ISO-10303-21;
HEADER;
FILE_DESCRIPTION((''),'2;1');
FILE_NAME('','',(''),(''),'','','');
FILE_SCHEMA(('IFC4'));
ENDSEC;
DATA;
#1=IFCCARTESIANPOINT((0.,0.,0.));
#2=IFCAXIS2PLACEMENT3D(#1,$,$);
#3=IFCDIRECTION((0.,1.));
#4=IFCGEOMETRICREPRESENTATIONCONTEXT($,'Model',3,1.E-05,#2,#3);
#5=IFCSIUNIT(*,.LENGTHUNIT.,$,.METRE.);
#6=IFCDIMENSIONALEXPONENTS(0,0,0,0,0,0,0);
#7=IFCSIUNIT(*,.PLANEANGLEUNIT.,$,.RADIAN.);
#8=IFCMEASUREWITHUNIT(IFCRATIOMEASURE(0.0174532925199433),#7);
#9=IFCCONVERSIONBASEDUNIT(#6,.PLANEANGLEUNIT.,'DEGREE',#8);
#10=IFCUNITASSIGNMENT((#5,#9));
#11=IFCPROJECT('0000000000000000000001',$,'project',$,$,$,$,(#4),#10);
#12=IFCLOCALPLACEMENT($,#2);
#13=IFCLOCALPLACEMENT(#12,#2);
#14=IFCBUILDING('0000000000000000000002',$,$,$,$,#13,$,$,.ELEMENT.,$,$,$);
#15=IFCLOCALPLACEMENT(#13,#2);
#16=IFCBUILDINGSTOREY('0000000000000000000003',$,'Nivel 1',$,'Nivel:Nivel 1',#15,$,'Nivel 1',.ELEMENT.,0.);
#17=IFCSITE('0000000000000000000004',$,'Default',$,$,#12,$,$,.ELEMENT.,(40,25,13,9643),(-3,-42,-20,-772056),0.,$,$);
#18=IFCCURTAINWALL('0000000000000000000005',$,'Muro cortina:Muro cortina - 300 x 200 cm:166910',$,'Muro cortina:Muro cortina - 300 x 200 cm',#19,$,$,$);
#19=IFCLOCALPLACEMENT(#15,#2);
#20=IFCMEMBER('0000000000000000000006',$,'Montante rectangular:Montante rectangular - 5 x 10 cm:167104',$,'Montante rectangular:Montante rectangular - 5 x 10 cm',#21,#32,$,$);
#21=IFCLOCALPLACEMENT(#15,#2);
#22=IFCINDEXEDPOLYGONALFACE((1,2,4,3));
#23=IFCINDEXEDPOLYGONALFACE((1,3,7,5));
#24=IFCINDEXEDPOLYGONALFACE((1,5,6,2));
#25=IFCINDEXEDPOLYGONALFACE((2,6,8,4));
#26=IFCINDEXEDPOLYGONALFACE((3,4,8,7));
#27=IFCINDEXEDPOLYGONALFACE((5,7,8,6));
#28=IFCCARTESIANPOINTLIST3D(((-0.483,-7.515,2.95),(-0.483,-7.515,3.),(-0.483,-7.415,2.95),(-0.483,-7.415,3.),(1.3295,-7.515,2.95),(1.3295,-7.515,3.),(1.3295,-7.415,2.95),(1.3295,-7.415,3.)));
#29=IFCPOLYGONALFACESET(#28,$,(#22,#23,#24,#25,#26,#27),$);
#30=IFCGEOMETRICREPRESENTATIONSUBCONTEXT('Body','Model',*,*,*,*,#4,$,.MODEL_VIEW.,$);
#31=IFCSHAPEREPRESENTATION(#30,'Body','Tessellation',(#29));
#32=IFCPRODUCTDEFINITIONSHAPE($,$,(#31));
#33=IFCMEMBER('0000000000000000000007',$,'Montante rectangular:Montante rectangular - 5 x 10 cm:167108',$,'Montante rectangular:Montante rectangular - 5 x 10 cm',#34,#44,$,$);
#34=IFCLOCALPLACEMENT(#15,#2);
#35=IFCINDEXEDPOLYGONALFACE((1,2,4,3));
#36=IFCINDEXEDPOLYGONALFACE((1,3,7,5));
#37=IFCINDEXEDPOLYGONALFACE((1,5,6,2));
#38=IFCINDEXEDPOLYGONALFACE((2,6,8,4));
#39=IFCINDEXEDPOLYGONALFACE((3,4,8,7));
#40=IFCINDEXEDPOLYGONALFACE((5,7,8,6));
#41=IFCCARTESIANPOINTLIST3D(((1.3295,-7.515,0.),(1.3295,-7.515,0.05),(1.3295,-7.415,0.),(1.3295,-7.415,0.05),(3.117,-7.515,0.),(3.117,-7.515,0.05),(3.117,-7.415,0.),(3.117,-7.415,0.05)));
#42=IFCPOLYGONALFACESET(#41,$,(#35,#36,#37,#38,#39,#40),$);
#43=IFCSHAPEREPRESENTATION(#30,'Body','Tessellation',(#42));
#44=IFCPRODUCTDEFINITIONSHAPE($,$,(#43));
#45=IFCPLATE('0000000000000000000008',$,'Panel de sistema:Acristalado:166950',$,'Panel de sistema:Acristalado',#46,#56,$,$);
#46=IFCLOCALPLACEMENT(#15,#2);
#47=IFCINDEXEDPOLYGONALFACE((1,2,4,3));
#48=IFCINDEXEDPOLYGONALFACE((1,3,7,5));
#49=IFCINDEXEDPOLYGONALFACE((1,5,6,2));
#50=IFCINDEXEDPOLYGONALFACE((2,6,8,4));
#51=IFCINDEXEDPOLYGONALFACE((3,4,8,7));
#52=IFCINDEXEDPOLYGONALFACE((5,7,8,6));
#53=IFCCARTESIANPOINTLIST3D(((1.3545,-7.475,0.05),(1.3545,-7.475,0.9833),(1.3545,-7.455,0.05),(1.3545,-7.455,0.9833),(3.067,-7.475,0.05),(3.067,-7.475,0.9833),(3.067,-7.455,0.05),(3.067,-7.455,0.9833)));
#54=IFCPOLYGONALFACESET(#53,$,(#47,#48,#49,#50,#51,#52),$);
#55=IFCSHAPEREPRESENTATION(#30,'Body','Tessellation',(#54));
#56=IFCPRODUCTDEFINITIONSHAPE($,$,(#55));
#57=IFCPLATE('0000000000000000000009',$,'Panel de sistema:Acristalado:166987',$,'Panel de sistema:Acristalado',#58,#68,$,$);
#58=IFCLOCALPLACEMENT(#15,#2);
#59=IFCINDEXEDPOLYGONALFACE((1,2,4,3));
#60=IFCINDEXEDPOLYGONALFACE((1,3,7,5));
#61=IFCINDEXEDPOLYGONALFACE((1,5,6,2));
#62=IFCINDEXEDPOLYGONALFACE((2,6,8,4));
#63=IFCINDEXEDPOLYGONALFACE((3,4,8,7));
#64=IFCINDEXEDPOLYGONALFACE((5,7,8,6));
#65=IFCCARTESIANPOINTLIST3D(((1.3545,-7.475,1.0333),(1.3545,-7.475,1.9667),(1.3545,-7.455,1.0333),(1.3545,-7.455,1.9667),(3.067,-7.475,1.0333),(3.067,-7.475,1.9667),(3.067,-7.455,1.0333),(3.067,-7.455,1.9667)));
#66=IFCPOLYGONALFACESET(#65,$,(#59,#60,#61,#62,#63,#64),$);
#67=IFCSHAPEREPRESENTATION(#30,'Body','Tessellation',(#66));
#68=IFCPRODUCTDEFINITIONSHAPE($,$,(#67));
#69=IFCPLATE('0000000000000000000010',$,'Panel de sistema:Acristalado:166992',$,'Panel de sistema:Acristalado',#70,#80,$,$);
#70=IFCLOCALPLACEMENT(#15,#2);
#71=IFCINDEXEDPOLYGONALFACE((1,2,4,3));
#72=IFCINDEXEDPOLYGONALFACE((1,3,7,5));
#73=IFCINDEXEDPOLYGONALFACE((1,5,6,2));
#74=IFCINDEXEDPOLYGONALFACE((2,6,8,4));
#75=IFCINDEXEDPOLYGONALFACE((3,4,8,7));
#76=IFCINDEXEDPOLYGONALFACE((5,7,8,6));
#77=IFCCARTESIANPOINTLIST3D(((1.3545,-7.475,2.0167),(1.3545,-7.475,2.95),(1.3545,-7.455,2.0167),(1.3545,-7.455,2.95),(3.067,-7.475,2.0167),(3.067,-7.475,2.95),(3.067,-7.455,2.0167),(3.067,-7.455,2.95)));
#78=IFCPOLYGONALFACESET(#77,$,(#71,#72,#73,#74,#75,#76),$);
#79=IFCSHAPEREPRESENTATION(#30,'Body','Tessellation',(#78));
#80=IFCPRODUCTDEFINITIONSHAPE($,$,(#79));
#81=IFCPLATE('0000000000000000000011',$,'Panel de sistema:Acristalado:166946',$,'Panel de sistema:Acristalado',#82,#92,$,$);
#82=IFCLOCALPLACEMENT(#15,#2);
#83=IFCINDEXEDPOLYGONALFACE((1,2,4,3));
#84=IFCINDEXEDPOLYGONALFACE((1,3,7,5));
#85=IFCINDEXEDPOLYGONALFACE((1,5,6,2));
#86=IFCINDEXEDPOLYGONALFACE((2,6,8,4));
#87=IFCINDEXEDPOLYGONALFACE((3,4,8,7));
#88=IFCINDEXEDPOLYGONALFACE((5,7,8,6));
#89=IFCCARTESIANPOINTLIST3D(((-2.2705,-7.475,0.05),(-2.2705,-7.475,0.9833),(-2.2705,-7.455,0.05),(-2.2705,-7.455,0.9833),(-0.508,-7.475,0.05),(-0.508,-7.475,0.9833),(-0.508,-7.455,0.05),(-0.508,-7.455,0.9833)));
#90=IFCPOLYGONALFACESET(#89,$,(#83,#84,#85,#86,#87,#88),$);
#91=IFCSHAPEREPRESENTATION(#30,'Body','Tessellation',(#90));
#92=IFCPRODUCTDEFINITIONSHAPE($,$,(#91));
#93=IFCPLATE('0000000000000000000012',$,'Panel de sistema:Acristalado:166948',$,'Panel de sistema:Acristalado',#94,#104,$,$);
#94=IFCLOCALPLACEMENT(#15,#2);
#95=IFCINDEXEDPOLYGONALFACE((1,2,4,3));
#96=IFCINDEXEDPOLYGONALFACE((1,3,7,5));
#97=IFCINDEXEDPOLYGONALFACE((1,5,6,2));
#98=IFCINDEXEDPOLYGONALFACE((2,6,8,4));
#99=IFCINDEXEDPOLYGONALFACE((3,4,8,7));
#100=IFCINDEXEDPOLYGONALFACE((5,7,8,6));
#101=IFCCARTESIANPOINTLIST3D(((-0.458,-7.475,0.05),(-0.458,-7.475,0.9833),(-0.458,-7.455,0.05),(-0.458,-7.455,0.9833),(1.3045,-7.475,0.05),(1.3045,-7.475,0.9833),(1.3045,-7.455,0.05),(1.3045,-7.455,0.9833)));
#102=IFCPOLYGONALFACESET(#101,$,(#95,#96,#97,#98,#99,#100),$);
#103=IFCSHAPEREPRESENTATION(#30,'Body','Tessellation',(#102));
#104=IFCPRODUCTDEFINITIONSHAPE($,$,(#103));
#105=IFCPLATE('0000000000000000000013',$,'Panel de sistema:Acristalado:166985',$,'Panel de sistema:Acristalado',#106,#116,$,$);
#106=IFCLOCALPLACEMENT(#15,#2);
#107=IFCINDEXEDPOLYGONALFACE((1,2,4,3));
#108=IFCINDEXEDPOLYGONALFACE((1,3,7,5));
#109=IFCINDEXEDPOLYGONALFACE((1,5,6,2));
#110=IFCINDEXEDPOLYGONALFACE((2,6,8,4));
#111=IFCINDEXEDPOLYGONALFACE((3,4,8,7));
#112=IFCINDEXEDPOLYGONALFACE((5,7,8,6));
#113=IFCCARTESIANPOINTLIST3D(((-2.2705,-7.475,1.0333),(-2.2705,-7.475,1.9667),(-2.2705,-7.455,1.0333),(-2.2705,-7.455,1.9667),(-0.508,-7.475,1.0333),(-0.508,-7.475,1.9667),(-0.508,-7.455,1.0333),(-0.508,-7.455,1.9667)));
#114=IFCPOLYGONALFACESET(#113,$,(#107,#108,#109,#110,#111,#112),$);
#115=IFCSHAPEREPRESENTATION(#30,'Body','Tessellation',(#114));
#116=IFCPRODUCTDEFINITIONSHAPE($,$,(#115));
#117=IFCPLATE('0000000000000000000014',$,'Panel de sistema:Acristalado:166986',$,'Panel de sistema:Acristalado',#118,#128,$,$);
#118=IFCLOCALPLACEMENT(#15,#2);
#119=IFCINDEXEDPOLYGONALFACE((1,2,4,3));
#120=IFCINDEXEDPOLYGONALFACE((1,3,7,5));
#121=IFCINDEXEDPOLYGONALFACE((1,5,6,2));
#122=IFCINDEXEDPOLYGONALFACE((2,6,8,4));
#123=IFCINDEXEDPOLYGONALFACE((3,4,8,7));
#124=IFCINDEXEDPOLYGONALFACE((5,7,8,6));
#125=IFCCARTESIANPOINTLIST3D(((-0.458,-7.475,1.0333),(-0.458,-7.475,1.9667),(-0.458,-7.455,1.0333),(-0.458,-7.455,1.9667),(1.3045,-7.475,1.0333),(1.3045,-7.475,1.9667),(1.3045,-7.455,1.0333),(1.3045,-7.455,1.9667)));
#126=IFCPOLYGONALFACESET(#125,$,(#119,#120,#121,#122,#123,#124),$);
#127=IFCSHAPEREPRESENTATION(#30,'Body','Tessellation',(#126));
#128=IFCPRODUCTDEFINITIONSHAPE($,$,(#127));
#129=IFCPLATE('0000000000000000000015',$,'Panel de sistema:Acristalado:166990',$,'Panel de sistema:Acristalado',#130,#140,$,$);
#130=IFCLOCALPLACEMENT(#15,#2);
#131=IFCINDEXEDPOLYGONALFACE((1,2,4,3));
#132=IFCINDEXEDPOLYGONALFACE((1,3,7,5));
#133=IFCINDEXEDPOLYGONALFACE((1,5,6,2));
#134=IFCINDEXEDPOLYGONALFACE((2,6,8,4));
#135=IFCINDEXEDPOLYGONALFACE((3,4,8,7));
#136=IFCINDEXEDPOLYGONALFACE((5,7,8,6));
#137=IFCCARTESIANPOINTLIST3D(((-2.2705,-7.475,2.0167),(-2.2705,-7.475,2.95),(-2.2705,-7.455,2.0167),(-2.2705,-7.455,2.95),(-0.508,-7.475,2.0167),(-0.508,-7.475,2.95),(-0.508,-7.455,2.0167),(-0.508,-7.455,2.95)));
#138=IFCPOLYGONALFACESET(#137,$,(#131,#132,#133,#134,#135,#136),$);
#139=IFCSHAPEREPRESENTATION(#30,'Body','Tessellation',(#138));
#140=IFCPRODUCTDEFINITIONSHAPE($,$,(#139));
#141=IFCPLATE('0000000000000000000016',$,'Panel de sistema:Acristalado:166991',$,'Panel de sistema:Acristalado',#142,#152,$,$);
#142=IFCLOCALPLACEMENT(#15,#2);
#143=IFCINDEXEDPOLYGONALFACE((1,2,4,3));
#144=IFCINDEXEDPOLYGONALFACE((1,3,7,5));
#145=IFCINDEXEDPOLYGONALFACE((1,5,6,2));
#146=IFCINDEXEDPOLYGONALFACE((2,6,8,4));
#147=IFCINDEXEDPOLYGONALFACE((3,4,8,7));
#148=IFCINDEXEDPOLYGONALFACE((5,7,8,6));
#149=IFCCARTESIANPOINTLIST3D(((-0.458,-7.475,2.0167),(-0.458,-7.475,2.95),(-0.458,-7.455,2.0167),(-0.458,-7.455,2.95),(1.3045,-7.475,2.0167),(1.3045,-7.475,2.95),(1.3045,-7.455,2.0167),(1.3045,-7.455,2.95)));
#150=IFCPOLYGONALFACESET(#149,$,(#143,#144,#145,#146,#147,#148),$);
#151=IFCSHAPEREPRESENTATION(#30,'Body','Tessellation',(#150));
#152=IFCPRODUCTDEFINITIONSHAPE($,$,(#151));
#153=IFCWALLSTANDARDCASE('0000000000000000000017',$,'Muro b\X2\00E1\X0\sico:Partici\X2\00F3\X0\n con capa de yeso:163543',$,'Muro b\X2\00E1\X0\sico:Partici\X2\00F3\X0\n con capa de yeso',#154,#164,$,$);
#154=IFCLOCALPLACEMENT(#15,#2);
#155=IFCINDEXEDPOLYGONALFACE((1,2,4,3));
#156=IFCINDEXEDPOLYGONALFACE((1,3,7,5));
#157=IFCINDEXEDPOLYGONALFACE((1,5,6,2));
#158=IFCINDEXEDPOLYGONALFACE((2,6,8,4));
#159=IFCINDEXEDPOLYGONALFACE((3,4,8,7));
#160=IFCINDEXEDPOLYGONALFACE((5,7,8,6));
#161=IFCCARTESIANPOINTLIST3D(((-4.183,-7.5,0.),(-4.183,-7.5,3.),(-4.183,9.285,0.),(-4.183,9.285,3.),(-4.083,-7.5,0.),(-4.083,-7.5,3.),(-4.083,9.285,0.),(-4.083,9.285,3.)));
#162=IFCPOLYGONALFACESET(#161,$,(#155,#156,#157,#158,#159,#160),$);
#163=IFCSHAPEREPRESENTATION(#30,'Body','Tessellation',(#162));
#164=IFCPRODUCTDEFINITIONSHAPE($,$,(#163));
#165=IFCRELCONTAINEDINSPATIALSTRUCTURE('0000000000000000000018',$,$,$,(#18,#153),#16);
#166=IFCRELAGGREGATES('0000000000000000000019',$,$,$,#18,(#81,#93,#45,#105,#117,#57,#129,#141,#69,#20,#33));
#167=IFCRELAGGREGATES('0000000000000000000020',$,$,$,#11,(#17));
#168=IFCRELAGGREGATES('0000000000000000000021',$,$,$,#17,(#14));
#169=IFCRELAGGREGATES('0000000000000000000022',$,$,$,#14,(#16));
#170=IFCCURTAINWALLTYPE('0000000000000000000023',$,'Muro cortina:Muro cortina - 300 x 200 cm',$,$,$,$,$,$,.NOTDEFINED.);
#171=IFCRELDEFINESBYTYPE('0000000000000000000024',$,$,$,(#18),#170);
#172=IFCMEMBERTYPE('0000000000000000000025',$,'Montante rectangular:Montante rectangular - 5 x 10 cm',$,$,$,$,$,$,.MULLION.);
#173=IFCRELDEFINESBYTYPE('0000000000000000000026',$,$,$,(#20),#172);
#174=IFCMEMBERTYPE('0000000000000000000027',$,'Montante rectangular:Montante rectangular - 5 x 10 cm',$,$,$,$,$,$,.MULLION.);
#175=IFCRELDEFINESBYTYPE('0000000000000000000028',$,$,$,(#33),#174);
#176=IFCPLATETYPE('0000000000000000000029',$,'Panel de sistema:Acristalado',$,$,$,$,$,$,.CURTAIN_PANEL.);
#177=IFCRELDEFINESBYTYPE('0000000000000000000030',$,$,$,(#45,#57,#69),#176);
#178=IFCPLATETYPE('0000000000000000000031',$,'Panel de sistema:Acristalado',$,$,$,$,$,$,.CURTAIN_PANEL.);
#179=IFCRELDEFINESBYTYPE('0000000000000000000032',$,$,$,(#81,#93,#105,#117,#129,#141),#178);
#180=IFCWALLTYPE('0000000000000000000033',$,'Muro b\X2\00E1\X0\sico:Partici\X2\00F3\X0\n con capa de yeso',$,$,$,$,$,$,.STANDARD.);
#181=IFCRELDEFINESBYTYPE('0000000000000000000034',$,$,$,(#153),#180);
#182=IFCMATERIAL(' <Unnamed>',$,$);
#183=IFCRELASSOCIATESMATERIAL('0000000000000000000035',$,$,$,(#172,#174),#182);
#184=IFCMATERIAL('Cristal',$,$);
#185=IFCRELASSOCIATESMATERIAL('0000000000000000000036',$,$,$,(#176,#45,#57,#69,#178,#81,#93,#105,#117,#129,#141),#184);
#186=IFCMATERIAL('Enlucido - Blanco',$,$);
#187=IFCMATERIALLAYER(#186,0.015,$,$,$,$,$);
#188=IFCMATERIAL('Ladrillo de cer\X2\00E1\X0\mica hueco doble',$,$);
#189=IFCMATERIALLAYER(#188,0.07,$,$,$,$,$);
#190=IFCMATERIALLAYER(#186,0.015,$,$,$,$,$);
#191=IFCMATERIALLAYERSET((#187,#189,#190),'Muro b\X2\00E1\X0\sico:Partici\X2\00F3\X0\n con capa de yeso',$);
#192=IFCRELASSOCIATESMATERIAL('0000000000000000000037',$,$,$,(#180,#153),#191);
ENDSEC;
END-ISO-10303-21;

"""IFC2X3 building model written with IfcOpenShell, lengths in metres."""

from ifc_helpers import new_model, entity, si_unit, converted_unit, direction, frame, frame_2d, origin, origin_2d_with_axis, place, context, subcontext, project, spatial, rectangle, extrude, source, transform, mapped, material, layer, layer_set, layer_usage, type_object, type_shapes, element, aggregate, save


model = new_model("IFC2X3")

# Units and contexts
model_context = context("Model", 3, precision=1e-05, world=origin(), true_north=direction((0.0, 1.0)))
body_context = subcontext(model_context, "Body", "Model", "MODEL_VIEW")
ifc_project = project(units=[si_unit("LENGTHUNIT", "METRE"), converted_unit("PLANEANGLEUNIT", "DEGREE", entity("IfcRatioMeasure", 0.0174532925199433), si_unit("PLANEANGLEUNIT", "RADIAN"), dimensions=[0, 0, 0, 0, 0, 0, 0])], contexts=[model_context])

# Site, building, storey
site_placement = place(None, origin())
site = spatial("IfcSite", under=ifc_project, at=site_placement, Name="Default", CompositionType="ELEMENT", RefLatitude=(40, 25, 13, 9643), RefLongitude=(-3, -42, -20, -772056), RefElevation=0.0)
building_placement = place(site_placement, origin())
building = spatial("IfcBuilding", under=site, at=building_placement, CompositionType="ELEMENT")
storey_placement = place(building_placement, origin())
storey = spatial("IfcBuildingStorey", under=building, at=storey_placement, Name="Nivel 1", ObjectType="Nivel:Nivel 1", LongName="Nivel 1", CompositionType="ELEMENT", Elevation=0.0)

# Curtain wall, members, plates
curtain_wall_type = type_object("IfcCurtainWallType", Name="Muro cortina:Muro cortina - 300 x 200 cm", PredefinedType="NOTDEFINED")
curtain_wall_placement = place(storey_placement, origin())
curtain_wall = element("IfcCurtainWall", 1, at=curtain_wall_placement, inside=storey, type_object=curtain_wall_type, Name="Muro cortina:Muro cortina - 300 x 200 cm:166910", ObjectType="Muro cortina:Muro cortina - 300 x 200 cm")
ifc_material_1 = material(Name=" <Unnamed>")
member_type_1 = type_object("IfcMemberType", Name="Montante rectangular:Montante rectangular - 5 x 10 cm", PredefinedType="MULLION", material=ifc_material_1)
shared_shape_1 = source(origin(), body_context, "Body", "SweptSolid", [
    extrude(rectangle(XDim=0.1, YDim=0.05, at=origin_2d_with_axis()), frame((-0.025, 0.0, -1.8125), z_axis=(0.0, 0.0, 1.0), x_axis=(0.0, -1.0, 0.0)), (0.0, 0.0, 1.0), 1.8125),
])
type_shapes(member_type_1, [shared_shape_1])
member_1_placement = place(storey_placement, frame((1.3295, -7.465, 3.0), z_axis=(1.0, 0.0, 0.0), x_axis=(0.0, 0.0, 1.0)))
member_1 = element("IfcMember", 2, at=member_1_placement, type_object=member_type_1, Name="Montante rectangular:Montante rectangular - 5 x 10 cm:167104", ObjectType="Montante rectangular:Montante rectangular - 5 x 10 cm", context=body_context, shape_type="MappedRepresentation", body=[
    mapped(shared_shape_1, transform((0.0, 0.0, 0.0), scale=1.0)),
])
member_type_2 = type_object("IfcMemberType", Name="Montante rectangular:Montante rectangular - 5 x 10 cm", PredefinedType="MULLION", material=ifc_material_1)
shared_shape_2 = source(origin(), body_context, "Body", "SweptSolid", [
    extrude(rectangle(XDim=0.1, YDim=0.05, at=origin_2d_with_axis()), frame((-0.025, 0.0, -1.7875), z_axis=(0.0, 0.0, 1.0), x_axis=(0.0, -1.0, 0.0)), (0.0, 0.0, 1.0), 1.7875),
])
type_shapes(member_type_2, [shared_shape_2])
member_2_placement = place(storey_placement, frame((1.3295, -7.465, 0.0), z_axis=(-1.0, 0.0, 0.0), x_axis=(0.0, 0.0, -1.0)))
member_2 = element("IfcMember", 3, at=member_2_placement, type_object=member_type_2, Name="Montante rectangular:Montante rectangular - 5 x 10 cm:167108", ObjectType="Montante rectangular:Montante rectangular - 5 x 10 cm", context=body_context, shape_type="MappedRepresentation", body=[
    mapped(shared_shape_2, transform((0.0, 0.0, 0.0), scale=1.0)),
])
ifc_material_2 = material(Name="Cristal")
plate_type_1 = type_object("IfcPlateType", Name="Panel de sistema:Acristalado", PredefinedType="CURTAIN_PANEL", material=ifc_material_2)
shared_shape_3 = source(origin(), body_context, "Body", "SweptSolid", [
    extrude(rectangle(XDim=0.02, YDim=1.7125, at=origin_2d_with_axis()), frame((0.0, 0.0, 0.0), z_axis=(0.0, 0.0, 1.0), x_axis=(0.0, 1.0, 0.0)), (0.0, 0.0, 1.0), 0.9333),
])
type_shapes(plate_type_1, [shared_shape_3])
plate_1_placement = place(curtain_wall_placement, frame((2.2107, -7.465, 0.05)))
plate_1 = element("IfcPlate", 4, at=plate_1_placement, type_object=plate_type_1, material=ifc_material_2, Name="Panel de sistema:Acristalado:166950", ObjectType="Panel de sistema:Acristalado", context=body_context, shape_type="MappedRepresentation", body=[
    mapped(shared_shape_3, transform((0.0, 0.0, 0.0), scale=1.0)),
])
plate_2_placement = place(curtain_wall_placement, frame((2.2107, -7.465, 1.0333)))
plate_2 = element("IfcPlate", 5, at=plate_2_placement, type_object=plate_type_1, material=ifc_material_2, Name="Panel de sistema:Acristalado:166987", ObjectType="Panel de sistema:Acristalado", context=body_context, shape_type="MappedRepresentation", body=[
    mapped(shared_shape_3, transform((0.0, 0.0, 0.0), scale=1.0)),
])
plate_3_placement = place(curtain_wall_placement, frame((2.2107, -7.465, 2.0167)))
plate_3 = element("IfcPlate", 6, at=plate_3_placement, type_object=plate_type_1, material=ifc_material_2, Name="Panel de sistema:Acristalado:166992", ObjectType="Panel de sistema:Acristalado", context=body_context, shape_type="MappedRepresentation", body=[
    mapped(shared_shape_3, transform((0.0, 0.0, 0.0), scale=1.0)),
])
plate_type_2 = type_object("IfcPlateType", Name="Panel de sistema:Acristalado", PredefinedType="CURTAIN_PANEL", material=ifc_material_2)
shared_shape_4 = source(origin(), body_context, "Body", "SweptSolid", [
    extrude(rectangle(XDim=0.02, YDim=1.7625, at=origin_2d_with_axis()), frame((0.0, 0.0, 0.0), z_axis=(0.0, 0.0, 1.0), x_axis=(0.0, 1.0, 0.0)), (0.0, 0.0, 1.0), 0.9333),
])
type_shapes(plate_type_2, [shared_shape_4])
plate_4_placement = place(curtain_wall_placement, frame((-1.3893, -7.465, 0.05)))
plate_4 = element("IfcPlate", 7, at=plate_4_placement, type_object=plate_type_2, material=ifc_material_2, Name="Panel de sistema:Acristalado:166946", ObjectType="Panel de sistema:Acristalado", context=body_context, shape_type="MappedRepresentation", body=[
    mapped(shared_shape_4, transform((0.0, 0.0, 0.0), scale=1.0)),
])
plate_5_placement = place(curtain_wall_placement, frame((0.4232, -7.465, 0.05)))
plate_5 = element("IfcPlate", 8, at=plate_5_placement, type_object=plate_type_2, material=ifc_material_2, Name="Panel de sistema:Acristalado:166948", ObjectType="Panel de sistema:Acristalado", context=body_context, shape_type="MappedRepresentation", body=[
    mapped(shared_shape_4, transform((0.0, 0.0, 0.0), scale=1.0)),
])
plate_6_placement = place(curtain_wall_placement, frame((-1.3893, -7.465, 1.0333)))
plate_6 = element("IfcPlate", 9, at=plate_6_placement, type_object=plate_type_2, material=ifc_material_2, Name="Panel de sistema:Acristalado:166985", ObjectType="Panel de sistema:Acristalado", context=body_context, shape_type="MappedRepresentation", body=[
    mapped(shared_shape_4, transform((0.0, 0.0, 0.0), scale=1.0)),
])
plate_7_placement = place(curtain_wall_placement, frame((0.4232, -7.465, 1.0333)))
plate_7 = element("IfcPlate", 10, at=plate_7_placement, type_object=plate_type_2, material=ifc_material_2, Name="Panel de sistema:Acristalado:166986", ObjectType="Panel de sistema:Acristalado", context=body_context, shape_type="MappedRepresentation", body=[
    mapped(shared_shape_4, transform((0.0, 0.0, 0.0), scale=1.0)),
])
plate_8_placement = place(curtain_wall_placement, frame((-1.3893, -7.465, 2.0167)))
plate_8 = element("IfcPlate", 11, at=plate_8_placement, type_object=plate_type_2, material=ifc_material_2, Name="Panel de sistema:Acristalado:166990", ObjectType="Panel de sistema:Acristalado", context=body_context, shape_type="MappedRepresentation", body=[
    mapped(shared_shape_4, transform((0.0, 0.0, 0.0), scale=1.0)),
])
plate_9_placement = place(curtain_wall_placement, frame((0.4232, -7.465, 2.0167)))
plate_9 = element("IfcPlate", 12, at=plate_9_placement, type_object=plate_type_2, material=ifc_material_2, Name="Panel de sistema:Acristalado:166991", ObjectType="Panel de sistema:Acristalado", context=body_context, shape_type="MappedRepresentation", body=[
    mapped(shared_shape_4, transform((0.0, 0.0, 0.0), scale=1.0)),
])
aggregate(curtain_wall, [plate_4, plate_5, plate_1, plate_6, plate_7, plate_2, plate_8, plate_9, plate_3, member_1, member_2])

# Wall
ifc_material_3 = material(Name="Enlucido - Blanco")
ifc_layer_1 = layer(ifc_material_3, 0.015)
ifc_material_4 = material(Name="Ladrillo de cerámica hueco doble")
ifc_layer_2 = layer(ifc_material_4, 0.07)
ifc_layer_3 = layer(ifc_material_3, 0.015)
ifc_layer_set = layer_set([ifc_layer_1, ifc_layer_2, ifc_layer_3], Name="Muro básico:Partición con capa de yeso")
ifc_layer_usage = layer_usage(ifc_layer_set, "AXIS2", "NEGATIVE", 0.05)
wall_type = type_object("IfcWallType", Name="Muro básico:Partición con capa de yeso", PredefinedType="STANDARD", material=ifc_layer_set)
wall_placement = place(storey_placement, frame((-4.133, -7.5, 0.0), z_axis=(0.0, 0.0, 1.0), x_axis=(0.0, 1.0, 0.0)))
element("IfcWallStandardCase", 13, at=wall_placement, inside=storey, type_object=wall_type, material=ifc_layer_usage, Name="Muro básico:Partición con capa de yeso:163543", ObjectType="Muro básico:Partición con capa de yeso", context=body_context, shape_type="SweptSolid", body=[
    extrude(rectangle(XDim=16.785, YDim=0.1, at=frame_2d((8.3925, 0.0), x_axis=(-1.0, 0.0))), origin(), (0.0, 0.0, 1.0), 3.0),
])

save(model, "model.ifc")
